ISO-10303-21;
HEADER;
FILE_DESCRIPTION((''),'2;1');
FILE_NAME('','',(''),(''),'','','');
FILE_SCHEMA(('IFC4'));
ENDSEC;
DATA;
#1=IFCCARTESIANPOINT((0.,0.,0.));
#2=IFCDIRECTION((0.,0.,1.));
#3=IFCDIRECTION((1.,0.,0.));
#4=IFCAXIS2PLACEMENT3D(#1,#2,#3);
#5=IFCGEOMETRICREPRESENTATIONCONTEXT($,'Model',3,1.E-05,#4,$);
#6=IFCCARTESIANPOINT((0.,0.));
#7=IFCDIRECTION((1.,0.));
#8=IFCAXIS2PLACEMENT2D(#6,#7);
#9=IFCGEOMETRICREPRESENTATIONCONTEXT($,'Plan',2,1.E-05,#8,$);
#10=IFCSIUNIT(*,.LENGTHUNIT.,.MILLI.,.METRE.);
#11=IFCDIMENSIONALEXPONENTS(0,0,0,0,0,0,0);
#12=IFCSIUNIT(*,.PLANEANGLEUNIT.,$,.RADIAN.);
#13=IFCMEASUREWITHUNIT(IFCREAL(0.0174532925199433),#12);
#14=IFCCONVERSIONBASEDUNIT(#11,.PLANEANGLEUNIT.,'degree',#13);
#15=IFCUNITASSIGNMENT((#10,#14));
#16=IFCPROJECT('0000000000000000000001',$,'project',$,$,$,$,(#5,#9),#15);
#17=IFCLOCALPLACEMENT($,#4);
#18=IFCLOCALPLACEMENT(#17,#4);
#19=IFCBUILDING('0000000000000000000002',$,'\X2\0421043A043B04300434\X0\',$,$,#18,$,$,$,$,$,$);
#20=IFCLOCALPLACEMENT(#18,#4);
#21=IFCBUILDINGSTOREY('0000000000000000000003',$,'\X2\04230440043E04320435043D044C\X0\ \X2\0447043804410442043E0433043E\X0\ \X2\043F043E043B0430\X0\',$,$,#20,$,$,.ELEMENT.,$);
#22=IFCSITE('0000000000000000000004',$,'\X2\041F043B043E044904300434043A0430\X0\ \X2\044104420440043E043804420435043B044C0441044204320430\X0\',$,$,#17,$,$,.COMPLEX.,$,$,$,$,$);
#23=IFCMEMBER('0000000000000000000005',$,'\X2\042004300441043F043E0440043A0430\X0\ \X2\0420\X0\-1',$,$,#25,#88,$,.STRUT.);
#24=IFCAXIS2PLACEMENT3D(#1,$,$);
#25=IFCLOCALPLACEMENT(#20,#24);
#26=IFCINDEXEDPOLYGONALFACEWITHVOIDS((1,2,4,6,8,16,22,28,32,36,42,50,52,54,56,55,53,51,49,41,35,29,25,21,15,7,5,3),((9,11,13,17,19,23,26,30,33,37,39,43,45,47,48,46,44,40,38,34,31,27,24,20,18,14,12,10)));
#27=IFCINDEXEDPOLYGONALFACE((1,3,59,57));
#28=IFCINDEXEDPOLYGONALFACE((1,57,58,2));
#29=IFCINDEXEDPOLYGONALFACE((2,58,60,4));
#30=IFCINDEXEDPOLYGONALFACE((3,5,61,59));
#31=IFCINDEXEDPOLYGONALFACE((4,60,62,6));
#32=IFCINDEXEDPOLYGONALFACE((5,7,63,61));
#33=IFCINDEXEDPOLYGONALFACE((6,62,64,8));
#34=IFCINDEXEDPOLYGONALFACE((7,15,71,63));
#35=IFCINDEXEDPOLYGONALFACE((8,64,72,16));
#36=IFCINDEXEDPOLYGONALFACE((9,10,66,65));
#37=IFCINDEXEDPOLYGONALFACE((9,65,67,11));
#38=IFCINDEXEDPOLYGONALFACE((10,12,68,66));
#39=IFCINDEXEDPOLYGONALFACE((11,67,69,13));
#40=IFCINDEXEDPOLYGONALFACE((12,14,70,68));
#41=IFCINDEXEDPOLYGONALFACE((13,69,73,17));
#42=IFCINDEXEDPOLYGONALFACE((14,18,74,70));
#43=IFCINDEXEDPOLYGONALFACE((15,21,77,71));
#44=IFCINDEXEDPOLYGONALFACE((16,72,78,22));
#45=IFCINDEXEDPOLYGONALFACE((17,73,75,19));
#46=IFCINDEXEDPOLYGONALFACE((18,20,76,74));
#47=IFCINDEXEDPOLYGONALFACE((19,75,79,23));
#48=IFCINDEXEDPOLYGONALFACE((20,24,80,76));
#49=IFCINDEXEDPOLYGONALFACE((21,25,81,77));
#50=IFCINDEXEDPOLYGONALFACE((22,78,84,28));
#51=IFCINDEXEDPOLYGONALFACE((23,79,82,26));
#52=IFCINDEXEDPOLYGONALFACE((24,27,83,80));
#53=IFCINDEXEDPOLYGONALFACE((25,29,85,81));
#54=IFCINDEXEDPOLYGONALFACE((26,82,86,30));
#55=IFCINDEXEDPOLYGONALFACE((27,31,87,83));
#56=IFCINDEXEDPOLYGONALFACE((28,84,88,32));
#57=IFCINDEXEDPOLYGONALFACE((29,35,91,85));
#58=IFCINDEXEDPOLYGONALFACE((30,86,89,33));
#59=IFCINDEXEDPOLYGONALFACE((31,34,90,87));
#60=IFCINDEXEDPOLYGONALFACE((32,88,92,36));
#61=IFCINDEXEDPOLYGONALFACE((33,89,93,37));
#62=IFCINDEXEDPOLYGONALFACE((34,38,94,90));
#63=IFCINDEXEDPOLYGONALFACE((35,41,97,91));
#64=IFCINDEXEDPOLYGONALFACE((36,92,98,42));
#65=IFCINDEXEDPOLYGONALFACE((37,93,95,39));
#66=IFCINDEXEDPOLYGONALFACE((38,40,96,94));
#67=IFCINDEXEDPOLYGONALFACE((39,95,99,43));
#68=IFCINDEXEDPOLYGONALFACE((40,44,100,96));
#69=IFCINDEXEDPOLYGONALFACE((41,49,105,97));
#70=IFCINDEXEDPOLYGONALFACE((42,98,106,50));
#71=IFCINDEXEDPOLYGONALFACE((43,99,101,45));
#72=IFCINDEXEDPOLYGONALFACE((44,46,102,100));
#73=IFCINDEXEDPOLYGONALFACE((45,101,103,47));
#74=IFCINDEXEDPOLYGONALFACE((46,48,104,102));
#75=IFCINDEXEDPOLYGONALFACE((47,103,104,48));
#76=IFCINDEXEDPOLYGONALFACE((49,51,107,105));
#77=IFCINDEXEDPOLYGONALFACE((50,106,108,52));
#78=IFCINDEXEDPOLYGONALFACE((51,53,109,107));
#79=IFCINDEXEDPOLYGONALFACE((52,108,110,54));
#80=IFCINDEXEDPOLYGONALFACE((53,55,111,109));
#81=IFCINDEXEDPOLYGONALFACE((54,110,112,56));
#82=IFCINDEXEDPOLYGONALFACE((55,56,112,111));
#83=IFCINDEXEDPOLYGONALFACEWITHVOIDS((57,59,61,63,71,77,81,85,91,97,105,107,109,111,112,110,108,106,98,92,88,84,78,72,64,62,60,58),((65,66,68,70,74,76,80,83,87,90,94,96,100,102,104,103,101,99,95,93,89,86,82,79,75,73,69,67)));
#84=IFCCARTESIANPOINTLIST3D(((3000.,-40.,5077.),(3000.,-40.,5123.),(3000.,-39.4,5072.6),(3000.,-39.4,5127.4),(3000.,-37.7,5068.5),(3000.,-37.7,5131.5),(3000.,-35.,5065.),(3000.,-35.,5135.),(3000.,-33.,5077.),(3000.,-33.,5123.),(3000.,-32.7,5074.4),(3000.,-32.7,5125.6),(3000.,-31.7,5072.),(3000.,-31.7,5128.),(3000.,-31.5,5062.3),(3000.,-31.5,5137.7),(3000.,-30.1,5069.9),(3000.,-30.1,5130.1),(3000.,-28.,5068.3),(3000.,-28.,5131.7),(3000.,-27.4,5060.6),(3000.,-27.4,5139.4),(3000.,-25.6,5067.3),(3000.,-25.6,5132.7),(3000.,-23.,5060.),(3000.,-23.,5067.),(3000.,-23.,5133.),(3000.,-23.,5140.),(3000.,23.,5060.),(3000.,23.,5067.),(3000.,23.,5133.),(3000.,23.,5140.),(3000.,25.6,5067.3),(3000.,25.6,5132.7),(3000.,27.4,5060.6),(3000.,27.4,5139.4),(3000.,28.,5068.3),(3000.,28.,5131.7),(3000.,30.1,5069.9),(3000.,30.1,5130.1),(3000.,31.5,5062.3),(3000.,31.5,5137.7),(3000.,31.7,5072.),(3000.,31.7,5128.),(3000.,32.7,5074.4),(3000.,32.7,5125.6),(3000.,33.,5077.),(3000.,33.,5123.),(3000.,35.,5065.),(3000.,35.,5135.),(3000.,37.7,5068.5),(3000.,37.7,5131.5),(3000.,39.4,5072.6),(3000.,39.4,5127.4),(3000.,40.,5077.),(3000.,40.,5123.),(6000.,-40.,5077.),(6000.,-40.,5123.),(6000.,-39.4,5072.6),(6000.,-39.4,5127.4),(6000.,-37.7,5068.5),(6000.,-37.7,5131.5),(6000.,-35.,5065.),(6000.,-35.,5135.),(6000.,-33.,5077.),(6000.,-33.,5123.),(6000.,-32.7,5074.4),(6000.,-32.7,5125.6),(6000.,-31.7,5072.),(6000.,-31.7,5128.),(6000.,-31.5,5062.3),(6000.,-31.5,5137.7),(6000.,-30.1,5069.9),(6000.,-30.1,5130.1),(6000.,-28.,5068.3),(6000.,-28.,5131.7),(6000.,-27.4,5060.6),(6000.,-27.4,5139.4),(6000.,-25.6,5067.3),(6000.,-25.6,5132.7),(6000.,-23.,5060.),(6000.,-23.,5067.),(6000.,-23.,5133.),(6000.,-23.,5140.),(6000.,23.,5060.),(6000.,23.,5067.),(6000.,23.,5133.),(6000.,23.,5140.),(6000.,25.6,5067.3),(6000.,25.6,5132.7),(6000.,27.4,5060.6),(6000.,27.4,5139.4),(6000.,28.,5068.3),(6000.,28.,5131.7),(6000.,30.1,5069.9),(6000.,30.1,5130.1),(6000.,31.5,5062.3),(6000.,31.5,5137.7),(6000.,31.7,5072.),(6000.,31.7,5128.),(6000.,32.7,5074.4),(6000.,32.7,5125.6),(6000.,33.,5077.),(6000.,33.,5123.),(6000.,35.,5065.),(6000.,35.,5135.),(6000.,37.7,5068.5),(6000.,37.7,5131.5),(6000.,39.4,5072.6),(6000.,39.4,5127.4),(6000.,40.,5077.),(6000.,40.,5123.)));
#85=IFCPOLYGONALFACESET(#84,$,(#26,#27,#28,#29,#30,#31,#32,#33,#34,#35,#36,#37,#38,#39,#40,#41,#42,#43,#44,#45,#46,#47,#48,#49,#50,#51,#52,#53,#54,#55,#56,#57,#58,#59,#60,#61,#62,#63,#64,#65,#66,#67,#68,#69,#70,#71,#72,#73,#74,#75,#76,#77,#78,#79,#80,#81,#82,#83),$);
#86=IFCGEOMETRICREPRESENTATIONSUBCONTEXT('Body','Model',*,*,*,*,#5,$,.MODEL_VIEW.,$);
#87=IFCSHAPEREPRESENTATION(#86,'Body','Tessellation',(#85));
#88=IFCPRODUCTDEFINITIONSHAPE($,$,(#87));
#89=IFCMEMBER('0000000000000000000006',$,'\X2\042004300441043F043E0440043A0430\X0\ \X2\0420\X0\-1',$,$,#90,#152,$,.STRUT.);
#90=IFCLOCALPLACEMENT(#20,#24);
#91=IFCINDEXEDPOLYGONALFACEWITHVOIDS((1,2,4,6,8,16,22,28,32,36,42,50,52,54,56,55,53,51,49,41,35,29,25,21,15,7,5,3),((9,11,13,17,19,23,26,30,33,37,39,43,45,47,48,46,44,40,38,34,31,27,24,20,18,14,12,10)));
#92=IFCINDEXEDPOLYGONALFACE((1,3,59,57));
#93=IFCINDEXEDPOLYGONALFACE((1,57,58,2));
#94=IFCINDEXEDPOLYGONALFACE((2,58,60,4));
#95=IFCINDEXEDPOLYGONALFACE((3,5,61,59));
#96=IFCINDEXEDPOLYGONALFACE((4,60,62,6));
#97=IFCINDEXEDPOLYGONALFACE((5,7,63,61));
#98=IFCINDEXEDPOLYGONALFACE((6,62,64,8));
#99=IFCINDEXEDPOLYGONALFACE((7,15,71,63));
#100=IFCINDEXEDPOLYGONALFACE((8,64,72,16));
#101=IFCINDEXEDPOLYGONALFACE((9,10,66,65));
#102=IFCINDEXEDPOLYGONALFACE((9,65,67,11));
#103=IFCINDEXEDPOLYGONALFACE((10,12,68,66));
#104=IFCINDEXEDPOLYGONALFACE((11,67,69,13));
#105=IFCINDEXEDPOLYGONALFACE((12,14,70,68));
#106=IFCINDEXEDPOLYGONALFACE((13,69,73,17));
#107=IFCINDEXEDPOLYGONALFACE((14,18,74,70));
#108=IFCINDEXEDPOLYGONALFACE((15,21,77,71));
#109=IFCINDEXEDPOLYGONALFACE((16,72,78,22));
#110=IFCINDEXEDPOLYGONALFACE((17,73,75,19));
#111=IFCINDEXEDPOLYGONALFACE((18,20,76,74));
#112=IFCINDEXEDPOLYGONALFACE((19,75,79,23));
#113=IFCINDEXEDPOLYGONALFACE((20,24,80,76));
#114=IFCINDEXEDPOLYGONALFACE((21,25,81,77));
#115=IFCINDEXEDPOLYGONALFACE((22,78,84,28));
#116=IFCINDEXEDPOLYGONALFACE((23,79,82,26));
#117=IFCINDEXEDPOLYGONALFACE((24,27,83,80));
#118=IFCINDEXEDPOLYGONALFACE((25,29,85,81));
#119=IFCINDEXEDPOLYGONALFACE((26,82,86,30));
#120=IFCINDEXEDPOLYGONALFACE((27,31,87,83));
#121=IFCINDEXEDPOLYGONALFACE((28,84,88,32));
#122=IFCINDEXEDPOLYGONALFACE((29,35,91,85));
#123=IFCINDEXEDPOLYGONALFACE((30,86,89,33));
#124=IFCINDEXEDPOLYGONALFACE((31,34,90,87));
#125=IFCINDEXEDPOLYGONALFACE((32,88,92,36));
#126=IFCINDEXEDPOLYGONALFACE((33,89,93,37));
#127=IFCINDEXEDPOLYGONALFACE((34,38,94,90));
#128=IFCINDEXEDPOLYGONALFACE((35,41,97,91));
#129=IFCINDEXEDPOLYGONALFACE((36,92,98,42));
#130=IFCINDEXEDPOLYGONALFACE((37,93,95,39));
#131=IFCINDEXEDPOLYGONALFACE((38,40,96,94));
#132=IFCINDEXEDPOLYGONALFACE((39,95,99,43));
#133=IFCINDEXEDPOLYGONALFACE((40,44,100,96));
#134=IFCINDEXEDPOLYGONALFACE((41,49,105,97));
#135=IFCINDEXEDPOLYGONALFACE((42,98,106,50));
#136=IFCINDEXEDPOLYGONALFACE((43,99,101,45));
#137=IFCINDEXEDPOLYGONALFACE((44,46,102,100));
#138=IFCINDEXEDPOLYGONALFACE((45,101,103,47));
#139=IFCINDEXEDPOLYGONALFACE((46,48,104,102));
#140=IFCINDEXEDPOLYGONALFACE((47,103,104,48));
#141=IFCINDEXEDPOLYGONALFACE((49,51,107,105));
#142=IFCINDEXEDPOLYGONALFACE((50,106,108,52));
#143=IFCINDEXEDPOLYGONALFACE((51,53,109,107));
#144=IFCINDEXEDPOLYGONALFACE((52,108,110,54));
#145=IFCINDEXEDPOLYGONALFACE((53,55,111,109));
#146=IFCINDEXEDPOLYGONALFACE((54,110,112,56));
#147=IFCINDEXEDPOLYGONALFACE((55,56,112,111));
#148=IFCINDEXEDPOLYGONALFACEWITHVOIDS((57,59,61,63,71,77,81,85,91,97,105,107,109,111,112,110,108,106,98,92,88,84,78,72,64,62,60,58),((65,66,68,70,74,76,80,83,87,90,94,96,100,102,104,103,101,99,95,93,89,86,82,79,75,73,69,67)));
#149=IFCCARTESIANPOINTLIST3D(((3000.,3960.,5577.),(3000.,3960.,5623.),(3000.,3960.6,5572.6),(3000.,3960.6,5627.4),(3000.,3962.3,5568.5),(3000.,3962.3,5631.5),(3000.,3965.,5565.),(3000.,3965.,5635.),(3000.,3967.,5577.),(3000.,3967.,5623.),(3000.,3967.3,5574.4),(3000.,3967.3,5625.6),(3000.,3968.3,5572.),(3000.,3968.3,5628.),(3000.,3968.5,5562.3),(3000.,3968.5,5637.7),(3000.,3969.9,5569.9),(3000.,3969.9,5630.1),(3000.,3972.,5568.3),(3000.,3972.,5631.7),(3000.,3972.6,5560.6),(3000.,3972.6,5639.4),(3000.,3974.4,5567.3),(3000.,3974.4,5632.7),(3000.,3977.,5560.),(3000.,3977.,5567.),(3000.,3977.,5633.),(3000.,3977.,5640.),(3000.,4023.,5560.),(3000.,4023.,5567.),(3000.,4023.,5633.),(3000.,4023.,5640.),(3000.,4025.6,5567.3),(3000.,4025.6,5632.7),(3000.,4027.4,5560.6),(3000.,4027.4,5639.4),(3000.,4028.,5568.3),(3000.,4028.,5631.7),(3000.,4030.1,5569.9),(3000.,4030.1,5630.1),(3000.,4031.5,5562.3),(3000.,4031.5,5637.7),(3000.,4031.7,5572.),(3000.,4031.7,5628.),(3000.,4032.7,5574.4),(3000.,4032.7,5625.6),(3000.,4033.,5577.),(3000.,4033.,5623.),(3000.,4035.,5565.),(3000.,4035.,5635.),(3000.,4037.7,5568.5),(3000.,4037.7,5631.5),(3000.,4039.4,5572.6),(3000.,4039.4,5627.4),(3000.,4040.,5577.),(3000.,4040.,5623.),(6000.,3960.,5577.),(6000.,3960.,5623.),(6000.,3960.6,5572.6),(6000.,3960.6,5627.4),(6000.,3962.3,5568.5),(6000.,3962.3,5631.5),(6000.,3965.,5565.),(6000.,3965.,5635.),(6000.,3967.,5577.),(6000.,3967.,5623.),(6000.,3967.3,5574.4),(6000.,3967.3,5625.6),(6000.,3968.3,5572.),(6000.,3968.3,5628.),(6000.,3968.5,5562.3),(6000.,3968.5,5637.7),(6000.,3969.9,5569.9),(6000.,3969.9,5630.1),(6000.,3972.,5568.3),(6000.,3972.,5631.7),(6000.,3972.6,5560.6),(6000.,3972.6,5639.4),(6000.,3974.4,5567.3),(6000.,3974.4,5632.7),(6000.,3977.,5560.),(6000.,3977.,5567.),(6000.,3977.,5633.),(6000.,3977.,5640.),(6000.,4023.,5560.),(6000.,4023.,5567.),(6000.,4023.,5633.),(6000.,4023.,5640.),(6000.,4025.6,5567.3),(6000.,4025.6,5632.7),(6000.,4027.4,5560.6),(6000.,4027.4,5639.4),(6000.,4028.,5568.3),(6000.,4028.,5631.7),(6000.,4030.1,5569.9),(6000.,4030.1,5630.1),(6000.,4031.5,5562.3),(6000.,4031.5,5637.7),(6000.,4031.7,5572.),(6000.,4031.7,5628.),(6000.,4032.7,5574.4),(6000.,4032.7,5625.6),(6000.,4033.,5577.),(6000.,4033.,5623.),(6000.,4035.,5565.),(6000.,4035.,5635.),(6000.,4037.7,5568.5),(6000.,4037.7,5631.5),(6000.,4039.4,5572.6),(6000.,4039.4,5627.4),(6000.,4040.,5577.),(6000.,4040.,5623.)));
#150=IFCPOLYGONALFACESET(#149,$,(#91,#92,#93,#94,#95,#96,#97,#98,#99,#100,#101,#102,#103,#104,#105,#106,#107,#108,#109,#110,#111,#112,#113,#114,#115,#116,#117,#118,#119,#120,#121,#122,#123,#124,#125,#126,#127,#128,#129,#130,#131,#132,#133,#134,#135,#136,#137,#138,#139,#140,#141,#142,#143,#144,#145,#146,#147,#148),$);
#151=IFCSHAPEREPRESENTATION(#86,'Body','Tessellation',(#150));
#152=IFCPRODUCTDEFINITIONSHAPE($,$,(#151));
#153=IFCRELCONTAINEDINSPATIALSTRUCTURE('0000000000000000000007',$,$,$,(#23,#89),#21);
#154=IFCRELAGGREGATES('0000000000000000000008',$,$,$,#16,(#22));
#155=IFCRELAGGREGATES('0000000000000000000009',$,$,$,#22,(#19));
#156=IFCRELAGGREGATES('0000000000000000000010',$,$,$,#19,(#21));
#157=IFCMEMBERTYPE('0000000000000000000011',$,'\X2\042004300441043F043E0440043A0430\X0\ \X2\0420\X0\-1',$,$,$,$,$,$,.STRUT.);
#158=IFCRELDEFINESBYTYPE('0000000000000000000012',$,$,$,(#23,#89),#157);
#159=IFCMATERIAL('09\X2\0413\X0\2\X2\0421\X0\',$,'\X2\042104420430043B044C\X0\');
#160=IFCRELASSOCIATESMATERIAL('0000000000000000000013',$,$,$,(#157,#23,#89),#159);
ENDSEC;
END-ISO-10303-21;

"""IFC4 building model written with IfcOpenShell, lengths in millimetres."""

from ifc_helpers import new_model, entity, si_unit, converted_unit, frame, origin_with_axes, origin_2d_with_axis, place, context, subcontext, project, spatial, hollow_rectangle, extrude, material, material_profile, profile_set, profile_usage, type_object, element, save


model = new_model("IFC4")

# Units and contexts
model_context = context("Model", 3, precision=1e-05, world=origin_with_axes())
plan_context = context("Plan", 2, precision=1e-05, world=origin_2d_with_axis())
body_context = subcontext(model_context, "Body", "Model", "MODEL_VIEW")
ifc_project = project(units=[si_unit("LENGTHUNIT", "METRE", prefix="MILLI"), converted_unit("PLANEANGLEUNIT", "degree", entity("IfcReal", 0.0174532925199433), si_unit("PLANEANGLEUNIT", "RADIAN"), dimensions=[0, 0, 0, 0, 0, 0, 0])], contexts=[model_context, plan_context])

# Site, building, storey
site_placement = place(None, origin_with_axes())
site = spatial("IfcSite", under=ifc_project, at=site_placement, Name="Площадка строительства", CompositionType="COMPLEX")
building_placement = place(site_placement, origin_with_axes())
building = spatial("IfcBuilding", under=site, at=building_placement, Name="Склад")
storey_placement = place(building_placement, origin_with_axes())
storey = spatial("IfcBuildingStorey", under=building, at=storey_placement, Name="Уровень чистого пола", CompositionType="ELEMENT")

# Members
ifc_material_1 = material(Name="09Г2С", Category="Сталь")
ifc_material_profile_1 = material_profile(ifc_material_1, hollow_rectangle(XDim=80.0, YDim=80.0, WallThickness=7.0, InnerFilletRadius=10.0, OuterFilletRadius=17.0))
ifc_profile_set_1 = profile_set([ifc_material_profile_1], Name="PK80x7_09G2S")
ifc_profile_usage_1 = profile_usage(ifc_profile_set_1, cardinal=5)
member_type_1 = type_object("IfcMemberType", Name="Распорка Р-1", PredefinedType="STRUT", material=ifc_profile_set_1)
member_1_placement = place(storey_placement, frame((3000.0, 0.0, 5100.0), z_axis=(1.0, 0.0, 0.0), x_axis=(0.0, 1.0, 0.0)))
element("IfcMember", 1, at=member_1_placement, inside=storey, type_object=member_type_1, material=ifc_profile_usage_1, Name="Распорка Р-1", PredefinedType="STRUT", context=body_context, shape_type="SweptSolid", body=[
    extrude(hollow_rectangle(XDim=80.0, YDim=80.0, WallThickness=7.0, InnerFilletRadius=10.0, OuterFilletRadius=17.0), origin_with_axes(), (0.0, 0.0, 1.0), 3000.0),
])
ifc_profile_usage_2 = profile_usage(ifc_profile_set_1, cardinal=5)
member_2_placement = place(storey_placement, frame((3000.0, 4000.0, 5600.0), z_axis=(1.0, 0.0, 0.0), x_axis=(0.0, 1.0, 0.0)))
element("IfcMember", 2, at=member_2_placement, inside=storey, type_object=member_type_1, material=ifc_profile_usage_2, Name="Распорка Р-1", PredefinedType="STRUT", context=body_context, shape_type="SweptSolid", body=[
    extrude(hollow_rectangle(XDim=80.0, YDim=80.0, WallThickness=7.0, InnerFilletRadius=10.0, OuterFilletRadius=17.0), origin_with_axes(), (0.0, 0.0, 1.0), 3000.0),
])

save(model, "model.ifc")
